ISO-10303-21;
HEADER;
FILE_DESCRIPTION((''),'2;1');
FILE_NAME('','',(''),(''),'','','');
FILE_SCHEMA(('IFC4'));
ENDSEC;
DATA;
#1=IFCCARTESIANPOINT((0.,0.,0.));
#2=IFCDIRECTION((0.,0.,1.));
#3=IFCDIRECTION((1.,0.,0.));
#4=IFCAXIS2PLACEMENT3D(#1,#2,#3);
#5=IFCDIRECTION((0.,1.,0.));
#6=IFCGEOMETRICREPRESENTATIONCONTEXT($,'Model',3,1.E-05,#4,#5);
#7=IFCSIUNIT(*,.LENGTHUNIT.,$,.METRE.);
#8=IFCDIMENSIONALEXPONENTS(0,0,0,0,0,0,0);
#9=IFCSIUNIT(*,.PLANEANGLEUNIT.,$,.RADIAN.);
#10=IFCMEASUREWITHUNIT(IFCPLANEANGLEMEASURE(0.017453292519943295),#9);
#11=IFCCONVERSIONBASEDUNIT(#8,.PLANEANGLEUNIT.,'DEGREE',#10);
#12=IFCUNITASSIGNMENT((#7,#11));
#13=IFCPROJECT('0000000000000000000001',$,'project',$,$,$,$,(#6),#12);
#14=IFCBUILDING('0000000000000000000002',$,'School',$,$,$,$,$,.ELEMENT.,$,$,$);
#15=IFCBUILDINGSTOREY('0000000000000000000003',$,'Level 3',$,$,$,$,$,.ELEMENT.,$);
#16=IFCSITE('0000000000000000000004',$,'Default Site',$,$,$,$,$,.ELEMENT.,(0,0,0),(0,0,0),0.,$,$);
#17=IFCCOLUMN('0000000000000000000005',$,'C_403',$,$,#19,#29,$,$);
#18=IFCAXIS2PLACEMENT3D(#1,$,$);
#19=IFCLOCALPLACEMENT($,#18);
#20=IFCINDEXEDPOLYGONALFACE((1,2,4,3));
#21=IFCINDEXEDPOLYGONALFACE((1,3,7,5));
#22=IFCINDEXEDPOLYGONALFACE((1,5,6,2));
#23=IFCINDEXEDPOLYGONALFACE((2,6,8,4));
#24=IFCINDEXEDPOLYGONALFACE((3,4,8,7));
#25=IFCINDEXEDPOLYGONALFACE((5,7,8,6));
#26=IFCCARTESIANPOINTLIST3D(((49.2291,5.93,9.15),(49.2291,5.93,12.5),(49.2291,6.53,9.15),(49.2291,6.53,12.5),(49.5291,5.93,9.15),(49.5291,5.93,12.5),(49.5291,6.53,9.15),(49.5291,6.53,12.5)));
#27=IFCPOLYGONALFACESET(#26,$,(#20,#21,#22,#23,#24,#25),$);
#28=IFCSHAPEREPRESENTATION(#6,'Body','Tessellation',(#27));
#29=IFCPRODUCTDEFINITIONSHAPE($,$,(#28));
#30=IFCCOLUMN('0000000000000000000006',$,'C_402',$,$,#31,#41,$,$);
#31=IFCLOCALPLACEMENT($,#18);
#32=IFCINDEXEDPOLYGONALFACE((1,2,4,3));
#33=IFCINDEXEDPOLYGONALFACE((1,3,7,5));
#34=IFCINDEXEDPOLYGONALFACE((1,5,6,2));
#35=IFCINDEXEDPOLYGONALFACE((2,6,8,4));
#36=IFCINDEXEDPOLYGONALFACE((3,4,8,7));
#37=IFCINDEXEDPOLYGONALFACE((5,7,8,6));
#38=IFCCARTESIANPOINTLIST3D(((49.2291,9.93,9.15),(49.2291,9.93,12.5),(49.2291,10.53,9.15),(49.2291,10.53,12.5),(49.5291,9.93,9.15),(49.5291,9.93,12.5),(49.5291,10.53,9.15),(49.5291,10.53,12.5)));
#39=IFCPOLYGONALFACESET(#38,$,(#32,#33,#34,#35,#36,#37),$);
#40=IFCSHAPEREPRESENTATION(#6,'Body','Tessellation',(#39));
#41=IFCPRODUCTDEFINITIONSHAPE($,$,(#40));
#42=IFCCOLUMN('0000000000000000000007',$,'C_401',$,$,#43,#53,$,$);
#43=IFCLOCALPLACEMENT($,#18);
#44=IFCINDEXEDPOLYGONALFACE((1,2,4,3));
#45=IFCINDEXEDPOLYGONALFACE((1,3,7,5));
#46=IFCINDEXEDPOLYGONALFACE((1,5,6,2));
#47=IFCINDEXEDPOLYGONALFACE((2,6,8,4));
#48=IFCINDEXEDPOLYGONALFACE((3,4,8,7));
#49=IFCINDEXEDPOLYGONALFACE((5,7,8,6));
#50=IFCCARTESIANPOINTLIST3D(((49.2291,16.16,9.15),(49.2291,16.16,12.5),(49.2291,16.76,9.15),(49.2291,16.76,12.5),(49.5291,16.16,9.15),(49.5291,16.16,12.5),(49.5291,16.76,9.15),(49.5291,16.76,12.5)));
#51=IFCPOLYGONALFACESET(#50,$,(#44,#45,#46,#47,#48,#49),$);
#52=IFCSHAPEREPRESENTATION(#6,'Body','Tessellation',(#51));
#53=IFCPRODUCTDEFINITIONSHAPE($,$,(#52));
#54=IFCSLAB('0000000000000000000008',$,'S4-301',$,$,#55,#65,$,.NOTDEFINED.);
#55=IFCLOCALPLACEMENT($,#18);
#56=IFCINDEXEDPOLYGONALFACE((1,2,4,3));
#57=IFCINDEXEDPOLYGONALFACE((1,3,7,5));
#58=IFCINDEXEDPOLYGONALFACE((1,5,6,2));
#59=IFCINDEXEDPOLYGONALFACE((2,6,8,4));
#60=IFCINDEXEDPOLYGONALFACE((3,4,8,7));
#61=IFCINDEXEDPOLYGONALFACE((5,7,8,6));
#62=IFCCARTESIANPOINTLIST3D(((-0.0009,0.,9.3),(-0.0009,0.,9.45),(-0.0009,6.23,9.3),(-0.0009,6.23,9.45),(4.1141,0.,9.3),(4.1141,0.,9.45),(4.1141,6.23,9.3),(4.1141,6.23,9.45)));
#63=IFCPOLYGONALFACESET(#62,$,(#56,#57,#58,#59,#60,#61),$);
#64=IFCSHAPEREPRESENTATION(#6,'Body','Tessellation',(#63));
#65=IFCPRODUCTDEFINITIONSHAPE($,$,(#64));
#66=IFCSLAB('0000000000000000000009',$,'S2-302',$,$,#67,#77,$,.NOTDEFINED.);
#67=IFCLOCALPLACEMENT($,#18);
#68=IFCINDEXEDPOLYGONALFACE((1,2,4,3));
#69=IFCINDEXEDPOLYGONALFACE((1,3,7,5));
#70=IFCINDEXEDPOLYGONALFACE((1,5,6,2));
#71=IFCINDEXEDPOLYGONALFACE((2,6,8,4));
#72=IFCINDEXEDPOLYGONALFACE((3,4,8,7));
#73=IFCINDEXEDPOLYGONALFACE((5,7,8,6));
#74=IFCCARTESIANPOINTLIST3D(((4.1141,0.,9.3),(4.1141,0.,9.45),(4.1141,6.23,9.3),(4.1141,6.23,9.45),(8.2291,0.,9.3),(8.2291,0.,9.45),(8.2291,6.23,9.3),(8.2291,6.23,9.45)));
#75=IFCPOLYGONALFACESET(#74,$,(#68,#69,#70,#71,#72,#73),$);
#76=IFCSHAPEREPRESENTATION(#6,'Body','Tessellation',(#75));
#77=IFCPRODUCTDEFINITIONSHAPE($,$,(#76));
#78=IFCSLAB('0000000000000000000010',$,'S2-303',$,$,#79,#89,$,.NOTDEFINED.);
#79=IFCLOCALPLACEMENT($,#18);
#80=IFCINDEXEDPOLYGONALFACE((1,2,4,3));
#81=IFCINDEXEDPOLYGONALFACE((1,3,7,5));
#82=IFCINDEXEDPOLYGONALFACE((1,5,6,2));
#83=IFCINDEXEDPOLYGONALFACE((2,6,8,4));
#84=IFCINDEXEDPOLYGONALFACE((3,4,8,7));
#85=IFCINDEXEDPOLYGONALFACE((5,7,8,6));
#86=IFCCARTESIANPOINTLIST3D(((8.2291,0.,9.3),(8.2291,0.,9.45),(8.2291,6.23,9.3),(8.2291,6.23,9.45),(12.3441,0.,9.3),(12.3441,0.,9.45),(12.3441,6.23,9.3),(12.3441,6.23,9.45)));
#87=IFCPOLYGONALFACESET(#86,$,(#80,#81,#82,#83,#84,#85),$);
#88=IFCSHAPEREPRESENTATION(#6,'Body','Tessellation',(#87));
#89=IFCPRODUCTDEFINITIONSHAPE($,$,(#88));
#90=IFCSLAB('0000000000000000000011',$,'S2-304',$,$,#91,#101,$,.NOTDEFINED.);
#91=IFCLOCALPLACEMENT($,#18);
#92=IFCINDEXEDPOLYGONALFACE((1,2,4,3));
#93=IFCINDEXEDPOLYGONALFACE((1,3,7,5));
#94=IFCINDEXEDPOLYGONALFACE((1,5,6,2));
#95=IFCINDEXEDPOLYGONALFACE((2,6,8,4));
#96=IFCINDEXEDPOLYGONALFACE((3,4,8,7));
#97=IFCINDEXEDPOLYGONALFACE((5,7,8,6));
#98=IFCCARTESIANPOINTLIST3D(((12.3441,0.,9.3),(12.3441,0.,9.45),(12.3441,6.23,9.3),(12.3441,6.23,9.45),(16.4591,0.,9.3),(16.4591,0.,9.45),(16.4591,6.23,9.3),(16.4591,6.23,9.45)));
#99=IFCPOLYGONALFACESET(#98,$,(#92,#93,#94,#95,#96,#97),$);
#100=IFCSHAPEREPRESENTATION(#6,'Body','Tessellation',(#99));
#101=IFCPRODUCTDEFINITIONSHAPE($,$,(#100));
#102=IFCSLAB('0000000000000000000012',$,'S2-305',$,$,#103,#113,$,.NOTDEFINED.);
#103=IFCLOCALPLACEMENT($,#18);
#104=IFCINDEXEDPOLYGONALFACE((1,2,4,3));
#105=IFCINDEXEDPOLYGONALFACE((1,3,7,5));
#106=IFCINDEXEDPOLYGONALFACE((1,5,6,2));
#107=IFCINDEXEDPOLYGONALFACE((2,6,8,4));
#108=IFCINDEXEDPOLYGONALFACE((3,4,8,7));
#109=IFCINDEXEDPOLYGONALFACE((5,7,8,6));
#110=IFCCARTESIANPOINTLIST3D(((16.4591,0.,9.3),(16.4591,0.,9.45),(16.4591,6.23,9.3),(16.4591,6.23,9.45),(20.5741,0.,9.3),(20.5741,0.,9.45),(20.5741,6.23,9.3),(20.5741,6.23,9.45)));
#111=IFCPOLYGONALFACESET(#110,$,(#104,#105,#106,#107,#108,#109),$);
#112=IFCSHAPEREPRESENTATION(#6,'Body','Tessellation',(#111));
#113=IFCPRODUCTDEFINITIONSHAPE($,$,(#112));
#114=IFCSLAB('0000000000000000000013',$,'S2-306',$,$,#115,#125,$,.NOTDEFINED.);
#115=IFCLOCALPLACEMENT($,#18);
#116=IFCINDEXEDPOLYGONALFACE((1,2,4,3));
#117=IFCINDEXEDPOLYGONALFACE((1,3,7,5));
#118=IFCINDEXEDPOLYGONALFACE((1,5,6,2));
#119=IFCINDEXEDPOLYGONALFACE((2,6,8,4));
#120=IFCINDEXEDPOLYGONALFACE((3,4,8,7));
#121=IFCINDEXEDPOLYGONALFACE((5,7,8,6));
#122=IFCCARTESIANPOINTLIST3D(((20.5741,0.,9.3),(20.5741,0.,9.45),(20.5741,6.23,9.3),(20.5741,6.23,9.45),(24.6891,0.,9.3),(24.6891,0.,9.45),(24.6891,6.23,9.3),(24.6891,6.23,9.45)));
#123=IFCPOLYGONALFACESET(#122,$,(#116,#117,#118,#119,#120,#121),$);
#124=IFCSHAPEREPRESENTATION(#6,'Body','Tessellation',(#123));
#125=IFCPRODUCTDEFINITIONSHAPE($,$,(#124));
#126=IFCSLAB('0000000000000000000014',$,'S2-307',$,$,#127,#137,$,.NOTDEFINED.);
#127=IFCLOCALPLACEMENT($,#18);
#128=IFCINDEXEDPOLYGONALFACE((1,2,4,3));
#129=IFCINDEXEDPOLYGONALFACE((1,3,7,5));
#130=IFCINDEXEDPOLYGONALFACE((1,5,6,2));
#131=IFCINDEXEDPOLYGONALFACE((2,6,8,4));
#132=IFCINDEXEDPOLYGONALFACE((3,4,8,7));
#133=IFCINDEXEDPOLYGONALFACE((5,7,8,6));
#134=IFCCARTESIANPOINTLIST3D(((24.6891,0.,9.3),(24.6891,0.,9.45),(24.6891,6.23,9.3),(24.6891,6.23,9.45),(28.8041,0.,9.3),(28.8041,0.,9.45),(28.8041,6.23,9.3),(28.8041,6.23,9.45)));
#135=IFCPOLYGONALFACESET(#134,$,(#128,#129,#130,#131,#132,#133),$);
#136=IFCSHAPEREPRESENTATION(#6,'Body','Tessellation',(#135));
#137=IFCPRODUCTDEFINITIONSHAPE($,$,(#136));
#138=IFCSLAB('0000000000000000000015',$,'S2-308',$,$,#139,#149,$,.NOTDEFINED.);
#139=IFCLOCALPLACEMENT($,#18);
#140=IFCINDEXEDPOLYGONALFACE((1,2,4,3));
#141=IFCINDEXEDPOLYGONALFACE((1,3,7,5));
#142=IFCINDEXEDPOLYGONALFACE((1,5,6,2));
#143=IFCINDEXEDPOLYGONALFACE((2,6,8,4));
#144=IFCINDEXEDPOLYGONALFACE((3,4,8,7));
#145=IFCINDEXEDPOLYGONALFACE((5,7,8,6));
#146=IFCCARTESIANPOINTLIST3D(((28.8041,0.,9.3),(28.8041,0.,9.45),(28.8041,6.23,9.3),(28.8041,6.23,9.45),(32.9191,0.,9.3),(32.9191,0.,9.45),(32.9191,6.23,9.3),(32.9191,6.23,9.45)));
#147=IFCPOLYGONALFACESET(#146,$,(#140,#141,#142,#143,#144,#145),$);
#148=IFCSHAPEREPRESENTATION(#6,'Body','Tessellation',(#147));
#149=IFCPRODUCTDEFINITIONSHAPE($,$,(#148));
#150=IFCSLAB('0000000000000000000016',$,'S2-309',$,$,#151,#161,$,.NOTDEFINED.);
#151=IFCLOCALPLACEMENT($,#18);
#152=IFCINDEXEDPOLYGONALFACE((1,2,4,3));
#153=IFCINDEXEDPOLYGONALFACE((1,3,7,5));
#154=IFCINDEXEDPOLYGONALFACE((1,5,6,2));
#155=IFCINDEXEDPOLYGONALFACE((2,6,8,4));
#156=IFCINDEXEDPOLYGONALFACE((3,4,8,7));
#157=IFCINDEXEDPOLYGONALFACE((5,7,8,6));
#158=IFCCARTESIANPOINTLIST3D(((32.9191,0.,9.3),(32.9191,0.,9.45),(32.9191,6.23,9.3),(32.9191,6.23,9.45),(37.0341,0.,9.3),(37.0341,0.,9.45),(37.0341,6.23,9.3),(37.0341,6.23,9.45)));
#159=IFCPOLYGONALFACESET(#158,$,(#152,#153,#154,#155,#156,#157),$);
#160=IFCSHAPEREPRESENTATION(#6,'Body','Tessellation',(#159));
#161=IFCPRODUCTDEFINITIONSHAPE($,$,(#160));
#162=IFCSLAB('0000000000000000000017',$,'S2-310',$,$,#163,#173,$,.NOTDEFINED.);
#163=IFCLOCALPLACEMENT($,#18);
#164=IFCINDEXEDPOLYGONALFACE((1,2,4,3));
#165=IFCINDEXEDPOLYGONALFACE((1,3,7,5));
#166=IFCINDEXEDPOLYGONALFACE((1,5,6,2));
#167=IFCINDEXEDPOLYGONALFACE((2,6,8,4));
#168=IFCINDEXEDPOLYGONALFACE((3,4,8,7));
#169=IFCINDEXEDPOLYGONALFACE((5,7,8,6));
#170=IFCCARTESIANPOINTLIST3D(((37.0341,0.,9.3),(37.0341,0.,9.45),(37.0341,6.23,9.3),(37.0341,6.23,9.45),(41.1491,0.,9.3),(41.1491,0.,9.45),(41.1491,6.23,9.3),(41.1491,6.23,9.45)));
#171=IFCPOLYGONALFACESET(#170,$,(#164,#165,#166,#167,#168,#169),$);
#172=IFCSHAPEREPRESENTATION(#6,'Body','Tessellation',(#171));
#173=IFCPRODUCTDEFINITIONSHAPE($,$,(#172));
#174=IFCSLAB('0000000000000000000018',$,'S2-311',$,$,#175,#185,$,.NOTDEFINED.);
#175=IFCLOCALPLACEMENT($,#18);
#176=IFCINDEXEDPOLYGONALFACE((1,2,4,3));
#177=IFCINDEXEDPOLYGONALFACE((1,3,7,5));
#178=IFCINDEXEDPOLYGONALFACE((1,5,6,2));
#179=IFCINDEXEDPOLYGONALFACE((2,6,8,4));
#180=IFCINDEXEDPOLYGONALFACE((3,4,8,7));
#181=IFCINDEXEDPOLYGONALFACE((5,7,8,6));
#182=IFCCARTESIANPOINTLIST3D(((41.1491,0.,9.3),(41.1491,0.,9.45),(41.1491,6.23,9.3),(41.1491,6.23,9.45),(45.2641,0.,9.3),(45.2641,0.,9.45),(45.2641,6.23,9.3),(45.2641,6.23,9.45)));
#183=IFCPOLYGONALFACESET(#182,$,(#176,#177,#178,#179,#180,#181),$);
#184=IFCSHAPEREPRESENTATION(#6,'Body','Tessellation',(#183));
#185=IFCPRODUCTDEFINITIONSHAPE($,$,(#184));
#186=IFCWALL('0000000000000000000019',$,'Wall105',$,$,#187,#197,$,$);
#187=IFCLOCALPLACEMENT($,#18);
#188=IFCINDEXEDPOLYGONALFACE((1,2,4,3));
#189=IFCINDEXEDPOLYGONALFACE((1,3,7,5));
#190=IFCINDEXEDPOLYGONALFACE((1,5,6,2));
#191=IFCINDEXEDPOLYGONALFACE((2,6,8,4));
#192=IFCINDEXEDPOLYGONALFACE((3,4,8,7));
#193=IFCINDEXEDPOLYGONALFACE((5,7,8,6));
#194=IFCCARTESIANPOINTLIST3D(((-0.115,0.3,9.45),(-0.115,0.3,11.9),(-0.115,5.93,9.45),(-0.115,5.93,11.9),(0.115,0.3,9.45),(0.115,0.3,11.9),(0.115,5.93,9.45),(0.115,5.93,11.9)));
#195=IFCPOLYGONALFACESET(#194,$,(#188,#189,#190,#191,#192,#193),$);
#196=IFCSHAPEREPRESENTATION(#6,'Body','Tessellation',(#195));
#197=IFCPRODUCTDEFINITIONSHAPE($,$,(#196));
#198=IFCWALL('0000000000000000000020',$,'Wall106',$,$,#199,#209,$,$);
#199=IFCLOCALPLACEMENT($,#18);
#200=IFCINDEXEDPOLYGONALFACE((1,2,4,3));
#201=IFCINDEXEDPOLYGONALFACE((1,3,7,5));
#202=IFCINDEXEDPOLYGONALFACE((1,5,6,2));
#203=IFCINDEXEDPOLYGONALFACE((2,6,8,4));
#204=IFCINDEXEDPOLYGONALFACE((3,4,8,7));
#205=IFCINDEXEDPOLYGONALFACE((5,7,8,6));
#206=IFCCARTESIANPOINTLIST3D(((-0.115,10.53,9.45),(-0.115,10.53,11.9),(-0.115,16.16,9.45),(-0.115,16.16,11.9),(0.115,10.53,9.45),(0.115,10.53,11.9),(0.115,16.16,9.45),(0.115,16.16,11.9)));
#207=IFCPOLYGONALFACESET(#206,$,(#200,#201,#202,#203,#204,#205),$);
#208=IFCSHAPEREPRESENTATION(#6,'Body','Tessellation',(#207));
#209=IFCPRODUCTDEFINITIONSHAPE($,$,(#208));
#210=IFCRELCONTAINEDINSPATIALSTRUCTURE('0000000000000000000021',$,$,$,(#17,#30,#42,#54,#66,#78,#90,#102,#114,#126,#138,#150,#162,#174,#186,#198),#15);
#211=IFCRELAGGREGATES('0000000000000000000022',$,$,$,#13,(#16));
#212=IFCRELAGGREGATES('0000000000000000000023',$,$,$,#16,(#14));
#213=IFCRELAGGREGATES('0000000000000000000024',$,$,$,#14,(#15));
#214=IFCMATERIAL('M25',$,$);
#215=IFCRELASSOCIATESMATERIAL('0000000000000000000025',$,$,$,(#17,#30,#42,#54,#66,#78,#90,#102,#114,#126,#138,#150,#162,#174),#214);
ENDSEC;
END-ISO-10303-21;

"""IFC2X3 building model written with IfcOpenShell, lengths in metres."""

from ifc_helpers import new_model, entity, si_unit, converted_unit, direction, frame, frame_2d, origin_with_axes, place, context, project, spatial, rectangle, extrude, material, element, save


model = new_model("IFC2X3")

# Units and contexts
model_context = context("Model", 3, precision=1e-05, world=origin_with_axes(), true_north=direction((0.0, 1.0, 0.0)))
ifc_project = project(units=[si_unit("LENGTHUNIT", "METRE"), converted_unit("PLANEANGLEUNIT", "DEGREE", entity("IfcPlaneAngleMeasure", 0.017453292519943295), si_unit("PLANEANGLEUNIT", "RADIAN"), dimensions=[0, 0, 0, 0, 0, 0, 0])], contexts=[model_context])

# Site, building, storey
site = spatial("IfcSite", under=ifc_project, Name="Default Site", CompositionType="ELEMENT", RefLatitude=(0, 0, 0), RefLongitude=(0, 0, 0), RefElevation=0.0)
building = spatial("IfcBuilding", under=site, Name="School", CompositionType="ELEMENT")
storey = spatial("IfcBuildingStorey", under=building, Name="Level 3", CompositionType="ELEMENT")

# Columns
ifc_material = material(Name="M25")
placement = place(None, origin_with_axes())
element("IfcColumn", 1, at=placement, inside=storey, material=ifc_material, Name="C_403", context=model_context, shape_type="SweptSolid", body=[
    extrude(rectangle(XDim=0.3, YDim=0.6, at=frame_2d((0.0, 0.0), x_axis=(1.0, 0.0, 0.0))), frame((49.3791, 6.23, 9.15), z_axis=(0.0, 0.0, 1.0), x_axis=(1.0, 0.0, 0.0)), (0.0, 0.0, 1.0), 3.35),
])
element("IfcColumn", 2, at=placement, inside=storey, material=ifc_material, Name="C_402", context=model_context, shape_type="SweptSolid", body=[
    extrude(rectangle(XDim=0.3, YDim=0.6, at=frame_2d((0.0, 0.0), x_axis=(1.0, 0.0, 0.0))), frame((49.3791, 10.23, 9.15), z_axis=(0.0, 0.0, 1.0), x_axis=(1.0, 0.0, 0.0)), (0.0, 0.0, 1.0), 3.35),
])
element("IfcColumn", 3, at=placement, inside=storey, material=ifc_material, Name="C_401", context=model_context, shape_type="SweptSolid", body=[
    extrude(rectangle(XDim=0.3, YDim=0.6, at=frame_2d((0.0, 0.0), x_axis=(1.0, 0.0, 0.0))), frame((49.3791, 16.46, 9.15), z_axis=(0.0, 0.0, 1.0), x_axis=(1.0, 0.0, 0.0)), (0.0, 0.0, 1.0), 3.35),
])

# Slabs
element("IfcSlab", 4, at=placement, inside=storey, material=ifc_material, Name="S4-301", PredefinedType="NOTDEFINED", context=model_context, shape_type="SweptSolid", body=[
    extrude(rectangle(XDim=4.115, YDim=6.23, at=frame_2d((0.0, 0.0), x_axis=(1.0, 0.0, 0.0))), frame((2.0566, 3.115, 9.3), z_axis=(0.0, 0.0, 1.0), x_axis=(1.0, 0.0, 0.0)), (0.0, 0.0, 1.0), 0.15),
])
element("IfcSlab", 5, at=placement, inside=storey, material=ifc_material, Name="S2-302", PredefinedType="NOTDEFINED", context=model_context, shape_type="SweptSolid", body=[
    extrude(rectangle(XDim=4.115, YDim=6.23, at=frame_2d((0.0, 0.0), x_axis=(1.0, 0.0, 0.0))), frame((6.1716, 3.115, 9.3), z_axis=(0.0, 0.0, 1.0), x_axis=(1.0, 0.0, 0.0)), (0.0, 0.0, 1.0), 0.15),
])
element("IfcSlab", 6, at=placement, inside=storey, material=ifc_material, Name="S2-303", PredefinedType="NOTDEFINED", context=model_context, shape_type="SweptSolid", body=[
    extrude(rectangle(XDim=4.115, YDim=6.23, at=frame_2d((0.0, 0.0), x_axis=(1.0, 0.0, 0.0))), frame((10.2866, 3.115, 9.3), z_axis=(0.0, 0.0, 1.0), x_axis=(1.0, 0.0, 0.0)), (0.0, 0.0, 1.0), 0.15),
])
element("IfcSlab", 7, at=placement, inside=storey, material=ifc_material, Name="S2-304", PredefinedType="NOTDEFINED", context=model_context, shape_type="SweptSolid", body=[
    extrude(rectangle(XDim=4.115, YDim=6.23, at=frame_2d((0.0, 0.0), x_axis=(1.0, 0.0, 0.0))), frame((14.4016, 3.115, 9.3), z_axis=(0.0, 0.0, 1.0), x_axis=(1.0, 0.0, 0.0)), (0.0, 0.0, 1.0), 0.15),
])
element("IfcSlab", 8, at=placement, inside=storey, material=ifc_material, Name="S2-305", PredefinedType="NOTDEFINED", context=model_context, shape_type="SweptSolid", body=[
    extrude(rectangle(XDim=4.115, YDim=6.23, at=frame_2d((0.0, 0.0), x_axis=(1.0, 0.0, 0.0))), frame((18.5166, 3.115, 9.3), z_axis=(0.0, 0.0, 1.0), x_axis=(1.0, 0.0, 0.0)), (0.0, 0.0, 1.0), 0.15),
])
element("IfcSlab", 9, at=placement, inside=storey, material=ifc_material, Name="S2-306", PredefinedType="NOTDEFINED", context=model_context, shape_type="SweptSolid", body=[
    extrude(rectangle(XDim=4.115, YDim=6.23, at=frame_2d((0.0, 0.0), x_axis=(1.0, 0.0, 0.0))), frame((22.6316, 3.115, 9.3), z_axis=(0.0, 0.0, 1.0), x_axis=(1.0, 0.0, 0.0)), (0.0, 0.0, 1.0), 0.15),
])
element("IfcSlab", 10, at=placement, inside=storey, material=ifc_material, Name="S2-307", PredefinedType="NOTDEFINED", context=model_context, shape_type="SweptSolid", body=[
    extrude(rectangle(XDim=4.115, YDim=6.23, at=frame_2d((0.0, 0.0), x_axis=(1.0, 0.0, 0.0))), frame((26.7466, 3.115, 9.3), z_axis=(0.0, 0.0, 1.0), x_axis=(1.0, 0.0, 0.0)), (0.0, 0.0, 1.0), 0.15),
])
element("IfcSlab", 11, at=placement, inside=storey, material=ifc_material, Name="S2-308", PredefinedType="NOTDEFINED", context=model_context, shape_type="SweptSolid", body=[
    extrude(rectangle(XDim=4.115, YDim=6.23, at=frame_2d((0.0, 0.0), x_axis=(1.0, 0.0, 0.0))), frame((30.8616, 3.115, 9.3), z_axis=(0.0, 0.0, 1.0), x_axis=(1.0, 0.0, 0.0)), (0.0, 0.0, 1.0), 0.15),
])
element("IfcSlab", 12, at=placement, inside=storey, material=ifc_material, Name="S2-309", PredefinedType="NOTDEFINED", context=model_context, shape_type="SweptSolid", body=[
    extrude(rectangle(XDim=4.115, YDim=6.23, at=frame_2d((0.0, 0.0), x_axis=(1.0, 0.0, 0.0))), frame((34.9766, 3.115, 9.3), z_axis=(0.0, 0.0, 1.0), x_axis=(1.0, 0.0, 0.0)), (0.0, 0.0, 1.0), 0.15),
])
element("IfcSlab", 13, at=placement, inside=storey, material=ifc_material, Name="S2-310", PredefinedType="NOTDEFINED", context=model_context, shape_type="SweptSolid", body=[
    extrude(rectangle(XDim=4.115, YDim=6.23, at=frame_2d((0.0, 0.0), x_axis=(1.0, 0.0, 0.0))), frame((39.0916, 3.115, 9.3), z_axis=(0.0, 0.0, 1.0), x_axis=(1.0, 0.0, 0.0)), (0.0, 0.0, 1.0), 0.15),
])
element("IfcSlab", 14, at=placement, inside=storey, material=ifc_material, Name="S2-311", PredefinedType="NOTDEFINED", context=model_context, shape_type="SweptSolid", body=[
    extrude(rectangle(XDim=4.115, YDim=6.23, at=frame_2d((0.0, 0.0), x_axis=(1.0, 0.0, 0.0))), frame((43.2066, 3.115, 9.3), z_axis=(0.0, 0.0, 1.0), x_axis=(1.0, 0.0, 0.0)), (0.0, 0.0, 1.0), 0.15),
])

# Walls
element("IfcWall", 15, at=placement, inside=storey, Name="Wall105", context=model_context, shape_type="SweptSolid", body=[
    extrude(rectangle(XDim=5.63, YDim=0.23, at=frame_2d((0.0, 0.0), x_axis=(0.0, 1.0, 0.0))), frame((0.0, 3.115, 9.45), z_axis=(0.0, 0.0, 1.0), x_axis=(1.0, 0.0, 0.0)), (0.0, 0.0, 1.0), 2.45),
])
element("IfcWall", 16, at=placement, inside=storey, Name="Wall106", context=model_context, shape_type="SweptSolid", body=[
    extrude(rectangle(XDim=5.63, YDim=0.23, at=frame_2d((0.0, 0.0), x_axis=(0.0, 1.0, 0.0))), frame((0.0, 13.345, 9.45), z_axis=(0.0, 0.0, 1.0), x_axis=(1.0, 0.0, 0.0)), (0.0, 0.0, 1.0), 2.45),
])

save(model, "model.ifc")
